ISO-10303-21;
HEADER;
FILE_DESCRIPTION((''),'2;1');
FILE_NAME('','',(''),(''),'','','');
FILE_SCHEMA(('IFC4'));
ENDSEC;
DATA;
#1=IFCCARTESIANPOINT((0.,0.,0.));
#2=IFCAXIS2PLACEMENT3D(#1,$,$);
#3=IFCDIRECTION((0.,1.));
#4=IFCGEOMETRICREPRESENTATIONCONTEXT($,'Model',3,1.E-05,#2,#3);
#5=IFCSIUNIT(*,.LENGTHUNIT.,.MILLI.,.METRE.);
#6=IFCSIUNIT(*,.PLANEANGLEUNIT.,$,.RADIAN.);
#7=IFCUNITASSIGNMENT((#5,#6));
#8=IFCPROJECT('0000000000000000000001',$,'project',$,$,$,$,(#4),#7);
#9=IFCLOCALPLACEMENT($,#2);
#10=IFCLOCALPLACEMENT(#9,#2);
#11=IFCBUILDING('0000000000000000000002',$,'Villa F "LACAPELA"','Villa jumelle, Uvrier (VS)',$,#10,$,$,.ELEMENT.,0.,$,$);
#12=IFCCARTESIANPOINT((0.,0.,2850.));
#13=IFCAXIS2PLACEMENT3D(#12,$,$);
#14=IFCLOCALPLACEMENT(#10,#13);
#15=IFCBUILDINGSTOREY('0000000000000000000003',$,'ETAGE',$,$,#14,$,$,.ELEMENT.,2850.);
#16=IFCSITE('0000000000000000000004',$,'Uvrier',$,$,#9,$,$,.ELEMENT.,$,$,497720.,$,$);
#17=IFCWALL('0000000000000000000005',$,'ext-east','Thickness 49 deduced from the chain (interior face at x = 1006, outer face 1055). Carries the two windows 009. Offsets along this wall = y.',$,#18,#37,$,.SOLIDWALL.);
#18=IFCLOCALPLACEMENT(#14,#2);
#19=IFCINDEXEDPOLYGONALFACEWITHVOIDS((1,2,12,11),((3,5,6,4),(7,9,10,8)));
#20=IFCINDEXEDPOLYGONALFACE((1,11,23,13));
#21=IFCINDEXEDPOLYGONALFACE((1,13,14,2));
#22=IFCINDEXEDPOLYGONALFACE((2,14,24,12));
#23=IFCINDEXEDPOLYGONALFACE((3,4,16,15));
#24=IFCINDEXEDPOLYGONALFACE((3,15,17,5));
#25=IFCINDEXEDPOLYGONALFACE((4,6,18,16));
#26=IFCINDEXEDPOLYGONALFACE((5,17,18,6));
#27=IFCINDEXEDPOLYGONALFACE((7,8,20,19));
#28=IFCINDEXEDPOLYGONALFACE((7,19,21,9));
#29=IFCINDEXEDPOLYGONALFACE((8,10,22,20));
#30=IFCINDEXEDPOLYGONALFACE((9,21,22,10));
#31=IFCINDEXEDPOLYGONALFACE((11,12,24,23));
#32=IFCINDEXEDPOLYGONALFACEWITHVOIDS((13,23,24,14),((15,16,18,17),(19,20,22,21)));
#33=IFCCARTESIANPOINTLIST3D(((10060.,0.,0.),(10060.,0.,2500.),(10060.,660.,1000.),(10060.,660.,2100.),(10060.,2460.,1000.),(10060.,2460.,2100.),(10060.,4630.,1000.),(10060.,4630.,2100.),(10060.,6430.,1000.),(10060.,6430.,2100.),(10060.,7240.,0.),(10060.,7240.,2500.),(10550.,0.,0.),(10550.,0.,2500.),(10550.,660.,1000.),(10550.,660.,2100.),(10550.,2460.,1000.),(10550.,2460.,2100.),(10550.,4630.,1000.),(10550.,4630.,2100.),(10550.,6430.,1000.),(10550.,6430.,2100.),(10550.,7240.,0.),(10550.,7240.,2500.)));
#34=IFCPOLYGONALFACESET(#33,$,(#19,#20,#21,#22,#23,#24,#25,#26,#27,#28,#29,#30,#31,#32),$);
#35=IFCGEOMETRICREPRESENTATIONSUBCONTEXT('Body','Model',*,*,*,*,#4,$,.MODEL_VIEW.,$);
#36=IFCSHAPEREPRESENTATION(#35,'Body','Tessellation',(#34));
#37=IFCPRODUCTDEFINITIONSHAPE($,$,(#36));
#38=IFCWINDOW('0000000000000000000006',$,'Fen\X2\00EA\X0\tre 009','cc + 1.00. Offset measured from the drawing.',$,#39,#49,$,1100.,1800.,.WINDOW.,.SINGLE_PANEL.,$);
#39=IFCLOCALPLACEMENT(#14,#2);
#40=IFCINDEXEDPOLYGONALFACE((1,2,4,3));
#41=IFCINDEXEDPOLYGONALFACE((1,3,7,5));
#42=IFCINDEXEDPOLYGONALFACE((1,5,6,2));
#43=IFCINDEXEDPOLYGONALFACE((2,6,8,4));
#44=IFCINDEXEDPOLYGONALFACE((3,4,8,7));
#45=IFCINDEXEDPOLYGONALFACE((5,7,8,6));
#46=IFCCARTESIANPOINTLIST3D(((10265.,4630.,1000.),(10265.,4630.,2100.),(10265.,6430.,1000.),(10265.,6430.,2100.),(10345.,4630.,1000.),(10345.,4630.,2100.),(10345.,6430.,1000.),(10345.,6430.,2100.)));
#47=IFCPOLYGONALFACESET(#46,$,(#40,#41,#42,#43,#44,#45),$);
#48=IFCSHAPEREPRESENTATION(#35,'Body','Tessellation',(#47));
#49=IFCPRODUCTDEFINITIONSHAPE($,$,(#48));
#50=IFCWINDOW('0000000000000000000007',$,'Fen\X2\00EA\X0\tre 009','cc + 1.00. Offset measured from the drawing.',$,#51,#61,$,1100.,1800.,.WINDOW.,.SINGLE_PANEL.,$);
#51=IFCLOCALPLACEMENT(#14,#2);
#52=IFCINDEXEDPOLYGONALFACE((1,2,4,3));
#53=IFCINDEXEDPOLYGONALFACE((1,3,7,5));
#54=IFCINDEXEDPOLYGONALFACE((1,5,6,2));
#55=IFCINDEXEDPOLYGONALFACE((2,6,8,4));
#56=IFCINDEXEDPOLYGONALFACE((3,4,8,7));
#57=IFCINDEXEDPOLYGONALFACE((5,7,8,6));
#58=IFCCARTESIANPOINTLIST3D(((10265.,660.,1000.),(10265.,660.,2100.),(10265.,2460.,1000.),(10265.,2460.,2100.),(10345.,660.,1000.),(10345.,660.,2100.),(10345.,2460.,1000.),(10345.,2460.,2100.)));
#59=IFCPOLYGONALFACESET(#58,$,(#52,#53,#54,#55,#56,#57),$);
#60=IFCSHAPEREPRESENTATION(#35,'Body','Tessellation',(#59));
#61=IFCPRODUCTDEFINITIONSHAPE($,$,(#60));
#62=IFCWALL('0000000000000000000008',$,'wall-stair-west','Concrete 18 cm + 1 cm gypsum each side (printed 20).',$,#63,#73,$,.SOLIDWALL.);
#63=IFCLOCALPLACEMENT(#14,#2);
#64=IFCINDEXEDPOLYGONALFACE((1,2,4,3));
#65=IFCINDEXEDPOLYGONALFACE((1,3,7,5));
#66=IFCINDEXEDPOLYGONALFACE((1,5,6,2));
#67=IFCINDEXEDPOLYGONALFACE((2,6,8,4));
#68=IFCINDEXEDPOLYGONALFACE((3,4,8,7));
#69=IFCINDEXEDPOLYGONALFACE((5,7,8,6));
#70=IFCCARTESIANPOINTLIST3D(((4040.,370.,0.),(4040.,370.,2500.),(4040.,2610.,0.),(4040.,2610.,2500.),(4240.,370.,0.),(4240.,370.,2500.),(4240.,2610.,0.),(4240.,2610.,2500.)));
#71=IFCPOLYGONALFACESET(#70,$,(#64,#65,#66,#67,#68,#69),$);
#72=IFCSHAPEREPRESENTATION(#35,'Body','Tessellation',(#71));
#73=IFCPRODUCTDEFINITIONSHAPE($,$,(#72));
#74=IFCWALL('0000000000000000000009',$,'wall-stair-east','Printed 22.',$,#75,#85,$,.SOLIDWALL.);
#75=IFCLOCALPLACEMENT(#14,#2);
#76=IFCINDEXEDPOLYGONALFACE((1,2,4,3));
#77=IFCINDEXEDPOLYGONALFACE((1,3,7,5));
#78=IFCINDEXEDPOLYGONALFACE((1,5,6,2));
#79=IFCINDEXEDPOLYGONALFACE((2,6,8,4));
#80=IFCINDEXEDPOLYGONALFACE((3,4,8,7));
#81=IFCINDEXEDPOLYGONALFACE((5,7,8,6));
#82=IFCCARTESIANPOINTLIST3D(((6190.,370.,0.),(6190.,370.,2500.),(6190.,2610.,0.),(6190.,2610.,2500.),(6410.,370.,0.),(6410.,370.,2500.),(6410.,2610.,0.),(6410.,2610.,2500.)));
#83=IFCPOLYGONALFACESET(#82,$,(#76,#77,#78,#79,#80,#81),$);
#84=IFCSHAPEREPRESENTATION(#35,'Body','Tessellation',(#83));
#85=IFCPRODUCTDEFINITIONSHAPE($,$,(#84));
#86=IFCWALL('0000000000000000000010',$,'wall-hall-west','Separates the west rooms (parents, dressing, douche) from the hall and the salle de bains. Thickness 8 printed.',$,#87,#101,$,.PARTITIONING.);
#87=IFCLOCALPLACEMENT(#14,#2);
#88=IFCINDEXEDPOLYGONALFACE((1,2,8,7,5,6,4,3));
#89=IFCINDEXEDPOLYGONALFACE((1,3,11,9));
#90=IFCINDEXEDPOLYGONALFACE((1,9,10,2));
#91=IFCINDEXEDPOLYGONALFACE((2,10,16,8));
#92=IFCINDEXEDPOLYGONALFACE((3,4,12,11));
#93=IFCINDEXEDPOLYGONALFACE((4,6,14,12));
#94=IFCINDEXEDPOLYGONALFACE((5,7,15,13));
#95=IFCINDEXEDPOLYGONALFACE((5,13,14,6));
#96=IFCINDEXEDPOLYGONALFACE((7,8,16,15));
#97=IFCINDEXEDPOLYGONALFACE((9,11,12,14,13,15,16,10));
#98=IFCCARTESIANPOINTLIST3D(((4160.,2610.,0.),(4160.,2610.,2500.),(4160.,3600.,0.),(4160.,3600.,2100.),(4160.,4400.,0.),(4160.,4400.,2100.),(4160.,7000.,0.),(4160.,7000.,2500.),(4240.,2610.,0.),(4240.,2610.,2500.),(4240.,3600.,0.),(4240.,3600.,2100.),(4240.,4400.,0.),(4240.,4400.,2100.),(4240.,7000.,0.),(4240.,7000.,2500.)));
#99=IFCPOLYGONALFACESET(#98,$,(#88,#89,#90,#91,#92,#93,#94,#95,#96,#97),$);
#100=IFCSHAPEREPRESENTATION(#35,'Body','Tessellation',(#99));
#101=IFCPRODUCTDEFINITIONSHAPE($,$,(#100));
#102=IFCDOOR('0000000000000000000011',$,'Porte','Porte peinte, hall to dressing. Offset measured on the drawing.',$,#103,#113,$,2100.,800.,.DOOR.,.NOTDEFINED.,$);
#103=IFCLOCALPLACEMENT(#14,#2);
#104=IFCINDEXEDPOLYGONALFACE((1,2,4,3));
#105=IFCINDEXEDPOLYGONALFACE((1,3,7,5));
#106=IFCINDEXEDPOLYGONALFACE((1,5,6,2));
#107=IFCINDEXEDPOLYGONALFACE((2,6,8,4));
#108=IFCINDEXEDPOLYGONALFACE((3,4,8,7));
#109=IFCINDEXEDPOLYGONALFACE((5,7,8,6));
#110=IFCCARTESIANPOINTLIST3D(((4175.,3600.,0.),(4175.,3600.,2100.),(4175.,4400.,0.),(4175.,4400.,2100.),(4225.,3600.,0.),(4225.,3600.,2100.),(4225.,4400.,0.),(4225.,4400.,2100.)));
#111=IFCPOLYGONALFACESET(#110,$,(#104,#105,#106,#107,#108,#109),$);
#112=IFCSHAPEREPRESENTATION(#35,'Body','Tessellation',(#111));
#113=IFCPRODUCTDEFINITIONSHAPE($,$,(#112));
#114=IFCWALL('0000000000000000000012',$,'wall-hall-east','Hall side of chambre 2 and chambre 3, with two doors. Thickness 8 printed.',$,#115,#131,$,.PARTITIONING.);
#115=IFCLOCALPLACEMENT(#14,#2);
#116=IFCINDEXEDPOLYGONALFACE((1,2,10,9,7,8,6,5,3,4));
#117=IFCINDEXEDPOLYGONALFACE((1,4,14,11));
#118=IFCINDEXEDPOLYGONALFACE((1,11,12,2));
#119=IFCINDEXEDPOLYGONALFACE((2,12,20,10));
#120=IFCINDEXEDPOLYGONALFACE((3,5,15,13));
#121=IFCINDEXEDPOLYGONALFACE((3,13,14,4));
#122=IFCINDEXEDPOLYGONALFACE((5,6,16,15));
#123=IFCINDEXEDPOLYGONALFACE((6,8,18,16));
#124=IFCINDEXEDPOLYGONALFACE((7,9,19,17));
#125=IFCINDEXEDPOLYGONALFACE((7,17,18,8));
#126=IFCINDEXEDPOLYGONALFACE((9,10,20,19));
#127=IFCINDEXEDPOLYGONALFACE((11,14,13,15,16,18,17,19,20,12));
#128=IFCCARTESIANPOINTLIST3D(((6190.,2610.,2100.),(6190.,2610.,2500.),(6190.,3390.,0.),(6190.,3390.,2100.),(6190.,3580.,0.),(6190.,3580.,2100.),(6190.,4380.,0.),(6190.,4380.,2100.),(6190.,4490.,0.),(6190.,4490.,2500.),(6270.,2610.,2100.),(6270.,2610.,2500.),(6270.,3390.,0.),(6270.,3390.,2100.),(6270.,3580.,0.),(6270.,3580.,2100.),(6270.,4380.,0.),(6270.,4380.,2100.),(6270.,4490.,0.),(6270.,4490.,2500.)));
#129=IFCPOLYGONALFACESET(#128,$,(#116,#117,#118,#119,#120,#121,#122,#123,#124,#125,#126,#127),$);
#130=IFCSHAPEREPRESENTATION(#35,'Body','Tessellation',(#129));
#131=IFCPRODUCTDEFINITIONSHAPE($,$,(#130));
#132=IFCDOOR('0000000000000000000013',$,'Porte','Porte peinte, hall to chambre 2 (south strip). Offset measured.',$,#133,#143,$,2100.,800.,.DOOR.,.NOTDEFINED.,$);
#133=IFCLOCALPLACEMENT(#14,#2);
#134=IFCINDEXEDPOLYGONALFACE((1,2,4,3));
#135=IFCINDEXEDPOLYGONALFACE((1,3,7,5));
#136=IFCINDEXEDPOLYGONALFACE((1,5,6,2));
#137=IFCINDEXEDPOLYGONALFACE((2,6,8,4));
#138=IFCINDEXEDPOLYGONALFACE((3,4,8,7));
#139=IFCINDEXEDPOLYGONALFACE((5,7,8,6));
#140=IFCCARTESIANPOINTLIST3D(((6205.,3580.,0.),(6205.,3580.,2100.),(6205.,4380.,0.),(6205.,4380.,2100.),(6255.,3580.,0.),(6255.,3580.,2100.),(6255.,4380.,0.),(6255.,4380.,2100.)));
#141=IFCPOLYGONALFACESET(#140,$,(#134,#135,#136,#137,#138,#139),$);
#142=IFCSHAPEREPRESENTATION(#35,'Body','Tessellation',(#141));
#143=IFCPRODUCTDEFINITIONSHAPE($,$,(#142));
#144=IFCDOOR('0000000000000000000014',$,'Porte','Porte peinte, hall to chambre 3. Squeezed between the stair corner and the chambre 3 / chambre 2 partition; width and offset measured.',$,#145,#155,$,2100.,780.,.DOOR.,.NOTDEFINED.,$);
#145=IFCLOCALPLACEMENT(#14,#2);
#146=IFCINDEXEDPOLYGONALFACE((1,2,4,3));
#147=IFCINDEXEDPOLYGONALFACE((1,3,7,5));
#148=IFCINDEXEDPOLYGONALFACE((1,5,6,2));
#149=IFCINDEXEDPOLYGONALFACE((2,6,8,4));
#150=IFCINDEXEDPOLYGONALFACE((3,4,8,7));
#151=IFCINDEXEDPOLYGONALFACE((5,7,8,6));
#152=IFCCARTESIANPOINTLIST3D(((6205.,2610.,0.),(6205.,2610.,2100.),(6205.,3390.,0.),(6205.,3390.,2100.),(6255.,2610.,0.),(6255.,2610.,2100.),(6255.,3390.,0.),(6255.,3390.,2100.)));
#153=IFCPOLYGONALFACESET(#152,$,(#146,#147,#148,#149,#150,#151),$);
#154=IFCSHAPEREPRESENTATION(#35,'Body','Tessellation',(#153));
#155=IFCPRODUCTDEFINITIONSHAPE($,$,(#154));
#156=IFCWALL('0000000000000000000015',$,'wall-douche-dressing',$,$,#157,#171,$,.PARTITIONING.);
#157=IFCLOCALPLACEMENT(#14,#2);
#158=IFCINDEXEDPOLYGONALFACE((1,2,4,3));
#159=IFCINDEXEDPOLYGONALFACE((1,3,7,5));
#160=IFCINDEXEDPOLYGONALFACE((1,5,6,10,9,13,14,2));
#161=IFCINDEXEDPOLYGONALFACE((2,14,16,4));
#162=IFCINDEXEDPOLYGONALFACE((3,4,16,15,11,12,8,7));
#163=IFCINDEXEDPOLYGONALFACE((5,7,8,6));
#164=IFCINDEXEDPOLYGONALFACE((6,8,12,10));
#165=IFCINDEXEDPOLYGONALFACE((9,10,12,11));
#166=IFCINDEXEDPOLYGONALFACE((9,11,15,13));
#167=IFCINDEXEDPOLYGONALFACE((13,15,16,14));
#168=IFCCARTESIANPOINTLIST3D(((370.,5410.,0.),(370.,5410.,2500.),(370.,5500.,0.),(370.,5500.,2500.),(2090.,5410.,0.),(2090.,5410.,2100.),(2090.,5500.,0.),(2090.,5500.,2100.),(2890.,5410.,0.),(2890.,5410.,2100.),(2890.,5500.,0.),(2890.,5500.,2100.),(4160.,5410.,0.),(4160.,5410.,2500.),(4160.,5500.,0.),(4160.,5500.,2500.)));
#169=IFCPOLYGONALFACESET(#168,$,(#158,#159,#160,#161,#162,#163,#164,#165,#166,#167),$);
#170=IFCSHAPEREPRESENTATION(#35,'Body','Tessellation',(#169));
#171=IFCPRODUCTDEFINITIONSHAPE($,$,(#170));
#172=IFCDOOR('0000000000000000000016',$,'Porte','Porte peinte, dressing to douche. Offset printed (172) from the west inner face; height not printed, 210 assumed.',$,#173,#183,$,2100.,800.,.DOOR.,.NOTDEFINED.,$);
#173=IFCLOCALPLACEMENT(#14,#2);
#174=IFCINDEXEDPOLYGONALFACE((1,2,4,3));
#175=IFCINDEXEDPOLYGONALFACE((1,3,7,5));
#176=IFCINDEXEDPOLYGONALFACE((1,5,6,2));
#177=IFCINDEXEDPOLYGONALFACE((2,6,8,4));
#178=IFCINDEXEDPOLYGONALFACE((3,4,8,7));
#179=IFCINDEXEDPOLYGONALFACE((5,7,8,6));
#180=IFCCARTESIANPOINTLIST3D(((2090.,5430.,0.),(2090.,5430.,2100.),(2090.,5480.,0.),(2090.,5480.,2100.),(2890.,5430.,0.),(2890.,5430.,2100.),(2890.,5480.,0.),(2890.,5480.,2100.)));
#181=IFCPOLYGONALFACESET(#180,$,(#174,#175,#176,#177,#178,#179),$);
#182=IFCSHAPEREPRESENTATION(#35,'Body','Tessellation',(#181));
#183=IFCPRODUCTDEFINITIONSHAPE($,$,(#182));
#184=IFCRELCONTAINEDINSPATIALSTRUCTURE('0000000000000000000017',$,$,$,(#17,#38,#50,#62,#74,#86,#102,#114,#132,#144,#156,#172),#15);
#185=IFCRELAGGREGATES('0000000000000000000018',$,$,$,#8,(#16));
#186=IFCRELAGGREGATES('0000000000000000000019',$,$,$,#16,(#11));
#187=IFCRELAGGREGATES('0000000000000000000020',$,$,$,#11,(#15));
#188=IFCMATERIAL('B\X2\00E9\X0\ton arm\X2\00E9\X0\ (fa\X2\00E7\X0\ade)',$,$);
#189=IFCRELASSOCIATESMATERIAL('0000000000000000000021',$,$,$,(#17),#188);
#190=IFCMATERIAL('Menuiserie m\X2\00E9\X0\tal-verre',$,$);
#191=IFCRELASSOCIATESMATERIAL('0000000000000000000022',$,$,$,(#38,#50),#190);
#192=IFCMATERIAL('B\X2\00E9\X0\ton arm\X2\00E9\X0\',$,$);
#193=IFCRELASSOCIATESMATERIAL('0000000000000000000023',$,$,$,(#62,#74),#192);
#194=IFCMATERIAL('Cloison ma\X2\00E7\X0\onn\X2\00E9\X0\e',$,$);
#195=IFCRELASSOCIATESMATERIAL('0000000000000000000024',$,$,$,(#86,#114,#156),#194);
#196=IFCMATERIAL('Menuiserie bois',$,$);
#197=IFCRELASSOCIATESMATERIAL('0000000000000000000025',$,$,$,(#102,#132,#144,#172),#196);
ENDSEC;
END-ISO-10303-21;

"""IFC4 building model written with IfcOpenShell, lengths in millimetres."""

from ifc_helpers import new_model, si_unit, direction, frame, frame_2d, origin, place, context, subcontext, project, spatial, rectangle, extrude, material, element, fill, save


model = new_model("IFC4")

# Units and contexts
model_context = context("Model", 3, precision=1e-05, world=origin(), true_north=direction((0.0, 1.0)))
body_context = subcontext(model_context, "Body", "Model", "MODEL_VIEW")
ifc_project = project(units=[si_unit("LENGTHUNIT", "METRE", prefix="MILLI"), si_unit("PLANEANGLEUNIT", "RADIAN")], contexts=[model_context])

# Site, building, storey
site_placement = place(None, origin())
site = spatial("IfcSite", under=ifc_project, at=site_placement, Name="Uvrier", CompositionType="ELEMENT", RefElevation=497720.0)
building_placement = place(site_placement, origin())
building = spatial("IfcBuilding", under=site, at=building_placement, Name="Villa F \"LACAPELA\"", Description="Villa jumelle, Uvrier (VS)", CompositionType="ELEMENT", ElevationOfRefHeight=0.0)
storey_placement = place(building_placement, frame((0.0, 0.0, 2850.0)))
storey = spatial("IfcBuildingStorey", under=building, at=storey_placement, Name="ETAGE", CompositionType="ELEMENT", Elevation=2850.0)

# Wall, openings, windows
ifc_material_1 = material(Name="Béton armé (façade)")
wall_1_placement = place(storey_placement, frame((10305.0, 0.0, 0.0), z_axis=(0.0, 0.0, 1.0), x_axis=(0.0, 1.0, 0.0)))
wall_1 = element("IfcWall", 1, at=wall_1_placement, inside=storey, material=ifc_material_1, Name="ext-east", Description="Thickness 49 deduced from the chain (interior face at x = 1006, outer face 1055). Carries the two windows 009. Offsets along this wall = y.", PredefinedType="SOLIDWALL", context=body_context, shape_type="SweptSolid", body=[
    extrude(rectangle(XDim=7240.0, YDim=490.0, at=frame_2d((3620.0, 0.0))), origin(), (0.0, 0.0, 1.0), 2500.0),
])
opening_1_placement = place(wall_1_placement, frame((4630.0, 0.0, 1000.0)))
opening_1 = element("IfcOpeningElement", 2, at=opening_1_placement, cuts=wall_1, PredefinedType="OPENING", context=body_context, shape_type="SweptSolid", body=[
    extrude(rectangle(XDim=1800.0, YDim=690.0, at=frame_2d((900.0, 0.0))), origin(), (0.0, 0.0, 1.0), 1100.0),
])
opening_2_placement = place(wall_1_placement, frame((660.0, 0.0, 1000.0)))
opening_2 = element("IfcOpeningElement", 3, at=opening_2_placement, cuts=wall_1, PredefinedType="OPENING", context=body_context, shape_type="SweptSolid", body=[
    extrude(rectangle(XDim=1800.0, YDim=690.0, at=frame_2d((900.0, 0.0))), origin(), (0.0, 0.0, 1.0), 1100.0),
])
ifc_material_2 = material(Name="Menuiserie métal-verre")
window_1_placement = place(opening_1_placement, origin())
window_1 = element("IfcWindow", 4, at=window_1_placement, inside=storey, material=ifc_material_2, Name="Fenêtre 009", Description="cc + 1.00. Offset measured from the drawing.", OverallHeight=1100.0, OverallWidth=1800.0, PartitioningType="SINGLE_PANEL", PredefinedType="WINDOW", context=body_context, shape_type="SweptSolid", body=[
    extrude(rectangle(XDim=1800.0, YDim=80.0, at=frame_2d((900.0, 0.0))), origin(), (0.0, 0.0, 1.0), 1100.0),
])
fill(opening_1, window_1)
window_2_placement = place(opening_2_placement, origin())
window_2 = element("IfcWindow", 5, at=window_2_placement, inside=storey, material=ifc_material_2, Name="Fenêtre 009", Description="cc + 1.00. Offset measured from the drawing.", OverallHeight=1100.0, OverallWidth=1800.0, PartitioningType="SINGLE_PANEL", PredefinedType="WINDOW", context=body_context, shape_type="SweptSolid", body=[
    extrude(rectangle(XDim=1800.0, YDim=80.0, at=frame_2d((900.0, 0.0))), origin(), (0.0, 0.0, 1.0), 1100.0),
])
fill(opening_2, window_2)

# Walls
ifc_material_3 = material(Name="Béton armé")
wall_2_placement = place(storey_placement, frame((4140.0, 370.0, 0.0), z_axis=(0.0, 0.0, 1.0), x_axis=(0.0, 1.0, 0.0)))
element("IfcWall", 6, at=wall_2_placement, inside=storey, material=ifc_material_3, Name="wall-stair-west", Description="Concrete 18 cm + 1 cm gypsum each side (printed 20).", PredefinedType="SOLIDWALL", context=body_context, shape_type="SweptSolid", body=[
    extrude(rectangle(XDim=2240.0, YDim=200.0, at=frame_2d((1120.0, 0.0))), origin(), (0.0, 0.0, 1.0), 2500.0),
])
wall_3_placement = place(storey_placement, frame((6300.0, 370.0, 0.0), z_axis=(0.0, 0.0, 1.0), x_axis=(0.0, 1.0, 0.0)))
element("IfcWall", 7, at=wall_3_placement, inside=storey, material=ifc_material_3, Name="wall-stair-east", Description="Printed 22.", PredefinedType="SOLIDWALL", context=body_context, shape_type="SweptSolid", body=[
    extrude(rectangle(XDim=2240.0, YDim=220.0, at=frame_2d((1120.0, 0.0))), origin(), (0.0, 0.0, 1.0), 2500.0),
])

# Wall, opening, door
ifc_material_4 = material(Name="Cloison maçonnée")
wall_4_placement = place(storey_placement, frame((4200.0, 2610.0, 0.0), z_axis=(0.0, 0.0, 1.0), x_axis=(0.0, 1.0, 0.0)))
wall_4 = element("IfcWall", 8, at=wall_4_placement, inside=storey, material=ifc_material_4, Name="wall-hall-west", Description="Separates the west rooms (parents, dressing, douche) from the hall and the salle de bains. Thickness 8 printed.", PredefinedType="PARTITIONING", context=body_context, shape_type="SweptSolid", body=[
    extrude(rectangle(XDim=4390.0, YDim=80.0, at=frame_2d((2195.0, 0.0))), origin(), (0.0, 0.0, 1.0), 2500.0),
])
opening_3_placement = place(wall_4_placement, frame((990.0, 0.0, 0.0)))
opening_3 = element("IfcOpeningElement", 9, at=opening_3_placement, cuts=wall_4, PredefinedType="OPENING", context=body_context, shape_type="SweptSolid", body=[
    extrude(rectangle(XDim=800.0, YDim=280.0, at=frame_2d((400.0, 0.0))), origin(), (0.0, 0.0, 1.0), 2100.0),
])
ifc_material_5 = material(Name="Menuiserie bois")
door_1_placement = place(opening_3_placement, origin())
door_1 = element("IfcDoor", 10, at=door_1_placement, inside=storey, material=ifc_material_5, Name="Porte", Description="Porte peinte, hall to dressing. Offset measured on the drawing.", OperationType="NOTDEFINED", OverallHeight=2100.0, OverallWidth=800.0, PredefinedType="DOOR", context=body_context, shape_type="SweptSolid", body=[
    extrude(rectangle(XDim=800.0, YDim=50.0, at=frame_2d((400.0, 0.0))), origin(), (0.0, 0.0, 1.0), 2100.0),
])
fill(opening_3, door_1)

# Wall, openings, doors
wall_5_placement = place(storey_placement, frame((6230.0, 2610.0, 0.0), z_axis=(0.0, 0.0, 1.0), x_axis=(0.0, 1.0, 0.0)))
wall_5 = element("IfcWall", 11, at=wall_5_placement, inside=storey, material=ifc_material_4, Name="wall-hall-east", Description="Hall side of chambre 2 and chambre 3, with two doors. Thickness 8 printed.", PredefinedType="PARTITIONING", context=body_context, shape_type="SweptSolid", body=[
    extrude(rectangle(XDim=1880.0, YDim=80.0, at=frame_2d((940.0, 0.0))), origin(), (0.0, 0.0, 1.0), 2500.0),
])
opening_4_placement = place(wall_5_placement, frame((970.0, 0.0, 0.0)))
opening_4 = element("IfcOpeningElement", 12, at=opening_4_placement, cuts=wall_5, PredefinedType="OPENING", context=body_context, shape_type="SweptSolid", body=[
    extrude(rectangle(XDim=800.0, YDim=280.0, at=frame_2d((400.0, 0.0))), origin(), (0.0, 0.0, 1.0), 2100.0),
])
opening_5_placement = place(wall_5_placement, origin())
opening_5 = element("IfcOpeningElement", 13, at=opening_5_placement, cuts=wall_5, PredefinedType="OPENING", context=body_context, shape_type="SweptSolid", body=[
    extrude(rectangle(XDim=780.0, YDim=280.0, at=frame_2d((390.0, 0.0))), origin(), (0.0, 0.0, 1.0), 2100.0),
])
door_2_placement = place(opening_4_placement, origin())
door_2 = element("IfcDoor", 14, at=door_2_placement, inside=storey, material=ifc_material_5, Name="Porte", Description="Porte peinte, hall to chambre 2 (south strip). Offset measured.", OperationType="NOTDEFINED", OverallHeight=2100.0, OverallWidth=800.0, PredefinedType="DOOR", context=body_context, shape_type="SweptSolid", body=[
    extrude(rectangle(XDim=800.0, YDim=50.0, at=frame_2d((400.0, 0.0))), origin(), (0.0, 0.0, 1.0), 2100.0),
])
fill(opening_4, door_2)
door_3_placement = place(opening_5_placement, origin())
door_3 = element("IfcDoor", 15, at=door_3_placement, inside=storey, material=ifc_material_5, Name="Porte", Description="Porte peinte, hall to chambre 3. Squeezed between the stair corner and the chambre 3 / chambre 2 partition; width and offset measured.", OperationType="NOTDEFINED", OverallHeight=2100.0, OverallWidth=780.0, PredefinedType="DOOR", context=body_context, shape_type="SweptSolid", body=[
    extrude(rectangle(XDim=780.0, YDim=50.0, at=frame_2d((390.0, 0.0))), origin(), (0.0, 0.0, 1.0), 2100.0),
])
fill(opening_5, door_3)

# Wall, opening, door
wall_6_placement = place(storey_placement, frame((370.0, 5455.0, 0.0), z_axis=(0.0, 0.0, 1.0), x_axis=(1.0, 0.0, 0.0)))
wall_6 = element("IfcWall", 16, at=wall_6_placement, inside=storey, material=ifc_material_4, Name="wall-douche-dressing", PredefinedType="PARTITIONING", context=body_context, shape_type="SweptSolid", body=[
    extrude(rectangle(XDim=3790.0, YDim=90.0, at=frame_2d((1895.0, 0.0))), origin(), (0.0, 0.0, 1.0), 2500.0),
])
opening_6_placement = place(wall_6_placement, frame((1720.0, 0.0, 0.0)))
opening_6 = element("IfcOpeningElement", 17, at=opening_6_placement, cuts=wall_6, PredefinedType="OPENING", context=body_context, shape_type="SweptSolid", body=[
    extrude(rectangle(XDim=800.0, YDim=290.0, at=frame_2d((400.0, 0.0))), origin(), (0.0, 0.0, 1.0), 2100.0),
])
door_4_placement = place(opening_6_placement, origin())
door_4 = element("IfcDoor", 18, at=door_4_placement, inside=storey, material=ifc_material_5, Name="Porte", Description="Porte peinte, dressing to douche. Offset printed (172) from the west inner face; height not printed, 210 assumed.", OperationType="NOTDEFINED", OverallHeight=2100.0, OverallWidth=800.0, PredefinedType="DOOR", context=body_context, shape_type="SweptSolid", body=[
    extrude(rectangle(XDim=800.0, YDim=50.0, at=frame_2d((400.0, 0.0))), origin(), (0.0, 0.0, 1.0), 2100.0),
])
fill(opening_6, door_4)

save(model, "model.ifc")
